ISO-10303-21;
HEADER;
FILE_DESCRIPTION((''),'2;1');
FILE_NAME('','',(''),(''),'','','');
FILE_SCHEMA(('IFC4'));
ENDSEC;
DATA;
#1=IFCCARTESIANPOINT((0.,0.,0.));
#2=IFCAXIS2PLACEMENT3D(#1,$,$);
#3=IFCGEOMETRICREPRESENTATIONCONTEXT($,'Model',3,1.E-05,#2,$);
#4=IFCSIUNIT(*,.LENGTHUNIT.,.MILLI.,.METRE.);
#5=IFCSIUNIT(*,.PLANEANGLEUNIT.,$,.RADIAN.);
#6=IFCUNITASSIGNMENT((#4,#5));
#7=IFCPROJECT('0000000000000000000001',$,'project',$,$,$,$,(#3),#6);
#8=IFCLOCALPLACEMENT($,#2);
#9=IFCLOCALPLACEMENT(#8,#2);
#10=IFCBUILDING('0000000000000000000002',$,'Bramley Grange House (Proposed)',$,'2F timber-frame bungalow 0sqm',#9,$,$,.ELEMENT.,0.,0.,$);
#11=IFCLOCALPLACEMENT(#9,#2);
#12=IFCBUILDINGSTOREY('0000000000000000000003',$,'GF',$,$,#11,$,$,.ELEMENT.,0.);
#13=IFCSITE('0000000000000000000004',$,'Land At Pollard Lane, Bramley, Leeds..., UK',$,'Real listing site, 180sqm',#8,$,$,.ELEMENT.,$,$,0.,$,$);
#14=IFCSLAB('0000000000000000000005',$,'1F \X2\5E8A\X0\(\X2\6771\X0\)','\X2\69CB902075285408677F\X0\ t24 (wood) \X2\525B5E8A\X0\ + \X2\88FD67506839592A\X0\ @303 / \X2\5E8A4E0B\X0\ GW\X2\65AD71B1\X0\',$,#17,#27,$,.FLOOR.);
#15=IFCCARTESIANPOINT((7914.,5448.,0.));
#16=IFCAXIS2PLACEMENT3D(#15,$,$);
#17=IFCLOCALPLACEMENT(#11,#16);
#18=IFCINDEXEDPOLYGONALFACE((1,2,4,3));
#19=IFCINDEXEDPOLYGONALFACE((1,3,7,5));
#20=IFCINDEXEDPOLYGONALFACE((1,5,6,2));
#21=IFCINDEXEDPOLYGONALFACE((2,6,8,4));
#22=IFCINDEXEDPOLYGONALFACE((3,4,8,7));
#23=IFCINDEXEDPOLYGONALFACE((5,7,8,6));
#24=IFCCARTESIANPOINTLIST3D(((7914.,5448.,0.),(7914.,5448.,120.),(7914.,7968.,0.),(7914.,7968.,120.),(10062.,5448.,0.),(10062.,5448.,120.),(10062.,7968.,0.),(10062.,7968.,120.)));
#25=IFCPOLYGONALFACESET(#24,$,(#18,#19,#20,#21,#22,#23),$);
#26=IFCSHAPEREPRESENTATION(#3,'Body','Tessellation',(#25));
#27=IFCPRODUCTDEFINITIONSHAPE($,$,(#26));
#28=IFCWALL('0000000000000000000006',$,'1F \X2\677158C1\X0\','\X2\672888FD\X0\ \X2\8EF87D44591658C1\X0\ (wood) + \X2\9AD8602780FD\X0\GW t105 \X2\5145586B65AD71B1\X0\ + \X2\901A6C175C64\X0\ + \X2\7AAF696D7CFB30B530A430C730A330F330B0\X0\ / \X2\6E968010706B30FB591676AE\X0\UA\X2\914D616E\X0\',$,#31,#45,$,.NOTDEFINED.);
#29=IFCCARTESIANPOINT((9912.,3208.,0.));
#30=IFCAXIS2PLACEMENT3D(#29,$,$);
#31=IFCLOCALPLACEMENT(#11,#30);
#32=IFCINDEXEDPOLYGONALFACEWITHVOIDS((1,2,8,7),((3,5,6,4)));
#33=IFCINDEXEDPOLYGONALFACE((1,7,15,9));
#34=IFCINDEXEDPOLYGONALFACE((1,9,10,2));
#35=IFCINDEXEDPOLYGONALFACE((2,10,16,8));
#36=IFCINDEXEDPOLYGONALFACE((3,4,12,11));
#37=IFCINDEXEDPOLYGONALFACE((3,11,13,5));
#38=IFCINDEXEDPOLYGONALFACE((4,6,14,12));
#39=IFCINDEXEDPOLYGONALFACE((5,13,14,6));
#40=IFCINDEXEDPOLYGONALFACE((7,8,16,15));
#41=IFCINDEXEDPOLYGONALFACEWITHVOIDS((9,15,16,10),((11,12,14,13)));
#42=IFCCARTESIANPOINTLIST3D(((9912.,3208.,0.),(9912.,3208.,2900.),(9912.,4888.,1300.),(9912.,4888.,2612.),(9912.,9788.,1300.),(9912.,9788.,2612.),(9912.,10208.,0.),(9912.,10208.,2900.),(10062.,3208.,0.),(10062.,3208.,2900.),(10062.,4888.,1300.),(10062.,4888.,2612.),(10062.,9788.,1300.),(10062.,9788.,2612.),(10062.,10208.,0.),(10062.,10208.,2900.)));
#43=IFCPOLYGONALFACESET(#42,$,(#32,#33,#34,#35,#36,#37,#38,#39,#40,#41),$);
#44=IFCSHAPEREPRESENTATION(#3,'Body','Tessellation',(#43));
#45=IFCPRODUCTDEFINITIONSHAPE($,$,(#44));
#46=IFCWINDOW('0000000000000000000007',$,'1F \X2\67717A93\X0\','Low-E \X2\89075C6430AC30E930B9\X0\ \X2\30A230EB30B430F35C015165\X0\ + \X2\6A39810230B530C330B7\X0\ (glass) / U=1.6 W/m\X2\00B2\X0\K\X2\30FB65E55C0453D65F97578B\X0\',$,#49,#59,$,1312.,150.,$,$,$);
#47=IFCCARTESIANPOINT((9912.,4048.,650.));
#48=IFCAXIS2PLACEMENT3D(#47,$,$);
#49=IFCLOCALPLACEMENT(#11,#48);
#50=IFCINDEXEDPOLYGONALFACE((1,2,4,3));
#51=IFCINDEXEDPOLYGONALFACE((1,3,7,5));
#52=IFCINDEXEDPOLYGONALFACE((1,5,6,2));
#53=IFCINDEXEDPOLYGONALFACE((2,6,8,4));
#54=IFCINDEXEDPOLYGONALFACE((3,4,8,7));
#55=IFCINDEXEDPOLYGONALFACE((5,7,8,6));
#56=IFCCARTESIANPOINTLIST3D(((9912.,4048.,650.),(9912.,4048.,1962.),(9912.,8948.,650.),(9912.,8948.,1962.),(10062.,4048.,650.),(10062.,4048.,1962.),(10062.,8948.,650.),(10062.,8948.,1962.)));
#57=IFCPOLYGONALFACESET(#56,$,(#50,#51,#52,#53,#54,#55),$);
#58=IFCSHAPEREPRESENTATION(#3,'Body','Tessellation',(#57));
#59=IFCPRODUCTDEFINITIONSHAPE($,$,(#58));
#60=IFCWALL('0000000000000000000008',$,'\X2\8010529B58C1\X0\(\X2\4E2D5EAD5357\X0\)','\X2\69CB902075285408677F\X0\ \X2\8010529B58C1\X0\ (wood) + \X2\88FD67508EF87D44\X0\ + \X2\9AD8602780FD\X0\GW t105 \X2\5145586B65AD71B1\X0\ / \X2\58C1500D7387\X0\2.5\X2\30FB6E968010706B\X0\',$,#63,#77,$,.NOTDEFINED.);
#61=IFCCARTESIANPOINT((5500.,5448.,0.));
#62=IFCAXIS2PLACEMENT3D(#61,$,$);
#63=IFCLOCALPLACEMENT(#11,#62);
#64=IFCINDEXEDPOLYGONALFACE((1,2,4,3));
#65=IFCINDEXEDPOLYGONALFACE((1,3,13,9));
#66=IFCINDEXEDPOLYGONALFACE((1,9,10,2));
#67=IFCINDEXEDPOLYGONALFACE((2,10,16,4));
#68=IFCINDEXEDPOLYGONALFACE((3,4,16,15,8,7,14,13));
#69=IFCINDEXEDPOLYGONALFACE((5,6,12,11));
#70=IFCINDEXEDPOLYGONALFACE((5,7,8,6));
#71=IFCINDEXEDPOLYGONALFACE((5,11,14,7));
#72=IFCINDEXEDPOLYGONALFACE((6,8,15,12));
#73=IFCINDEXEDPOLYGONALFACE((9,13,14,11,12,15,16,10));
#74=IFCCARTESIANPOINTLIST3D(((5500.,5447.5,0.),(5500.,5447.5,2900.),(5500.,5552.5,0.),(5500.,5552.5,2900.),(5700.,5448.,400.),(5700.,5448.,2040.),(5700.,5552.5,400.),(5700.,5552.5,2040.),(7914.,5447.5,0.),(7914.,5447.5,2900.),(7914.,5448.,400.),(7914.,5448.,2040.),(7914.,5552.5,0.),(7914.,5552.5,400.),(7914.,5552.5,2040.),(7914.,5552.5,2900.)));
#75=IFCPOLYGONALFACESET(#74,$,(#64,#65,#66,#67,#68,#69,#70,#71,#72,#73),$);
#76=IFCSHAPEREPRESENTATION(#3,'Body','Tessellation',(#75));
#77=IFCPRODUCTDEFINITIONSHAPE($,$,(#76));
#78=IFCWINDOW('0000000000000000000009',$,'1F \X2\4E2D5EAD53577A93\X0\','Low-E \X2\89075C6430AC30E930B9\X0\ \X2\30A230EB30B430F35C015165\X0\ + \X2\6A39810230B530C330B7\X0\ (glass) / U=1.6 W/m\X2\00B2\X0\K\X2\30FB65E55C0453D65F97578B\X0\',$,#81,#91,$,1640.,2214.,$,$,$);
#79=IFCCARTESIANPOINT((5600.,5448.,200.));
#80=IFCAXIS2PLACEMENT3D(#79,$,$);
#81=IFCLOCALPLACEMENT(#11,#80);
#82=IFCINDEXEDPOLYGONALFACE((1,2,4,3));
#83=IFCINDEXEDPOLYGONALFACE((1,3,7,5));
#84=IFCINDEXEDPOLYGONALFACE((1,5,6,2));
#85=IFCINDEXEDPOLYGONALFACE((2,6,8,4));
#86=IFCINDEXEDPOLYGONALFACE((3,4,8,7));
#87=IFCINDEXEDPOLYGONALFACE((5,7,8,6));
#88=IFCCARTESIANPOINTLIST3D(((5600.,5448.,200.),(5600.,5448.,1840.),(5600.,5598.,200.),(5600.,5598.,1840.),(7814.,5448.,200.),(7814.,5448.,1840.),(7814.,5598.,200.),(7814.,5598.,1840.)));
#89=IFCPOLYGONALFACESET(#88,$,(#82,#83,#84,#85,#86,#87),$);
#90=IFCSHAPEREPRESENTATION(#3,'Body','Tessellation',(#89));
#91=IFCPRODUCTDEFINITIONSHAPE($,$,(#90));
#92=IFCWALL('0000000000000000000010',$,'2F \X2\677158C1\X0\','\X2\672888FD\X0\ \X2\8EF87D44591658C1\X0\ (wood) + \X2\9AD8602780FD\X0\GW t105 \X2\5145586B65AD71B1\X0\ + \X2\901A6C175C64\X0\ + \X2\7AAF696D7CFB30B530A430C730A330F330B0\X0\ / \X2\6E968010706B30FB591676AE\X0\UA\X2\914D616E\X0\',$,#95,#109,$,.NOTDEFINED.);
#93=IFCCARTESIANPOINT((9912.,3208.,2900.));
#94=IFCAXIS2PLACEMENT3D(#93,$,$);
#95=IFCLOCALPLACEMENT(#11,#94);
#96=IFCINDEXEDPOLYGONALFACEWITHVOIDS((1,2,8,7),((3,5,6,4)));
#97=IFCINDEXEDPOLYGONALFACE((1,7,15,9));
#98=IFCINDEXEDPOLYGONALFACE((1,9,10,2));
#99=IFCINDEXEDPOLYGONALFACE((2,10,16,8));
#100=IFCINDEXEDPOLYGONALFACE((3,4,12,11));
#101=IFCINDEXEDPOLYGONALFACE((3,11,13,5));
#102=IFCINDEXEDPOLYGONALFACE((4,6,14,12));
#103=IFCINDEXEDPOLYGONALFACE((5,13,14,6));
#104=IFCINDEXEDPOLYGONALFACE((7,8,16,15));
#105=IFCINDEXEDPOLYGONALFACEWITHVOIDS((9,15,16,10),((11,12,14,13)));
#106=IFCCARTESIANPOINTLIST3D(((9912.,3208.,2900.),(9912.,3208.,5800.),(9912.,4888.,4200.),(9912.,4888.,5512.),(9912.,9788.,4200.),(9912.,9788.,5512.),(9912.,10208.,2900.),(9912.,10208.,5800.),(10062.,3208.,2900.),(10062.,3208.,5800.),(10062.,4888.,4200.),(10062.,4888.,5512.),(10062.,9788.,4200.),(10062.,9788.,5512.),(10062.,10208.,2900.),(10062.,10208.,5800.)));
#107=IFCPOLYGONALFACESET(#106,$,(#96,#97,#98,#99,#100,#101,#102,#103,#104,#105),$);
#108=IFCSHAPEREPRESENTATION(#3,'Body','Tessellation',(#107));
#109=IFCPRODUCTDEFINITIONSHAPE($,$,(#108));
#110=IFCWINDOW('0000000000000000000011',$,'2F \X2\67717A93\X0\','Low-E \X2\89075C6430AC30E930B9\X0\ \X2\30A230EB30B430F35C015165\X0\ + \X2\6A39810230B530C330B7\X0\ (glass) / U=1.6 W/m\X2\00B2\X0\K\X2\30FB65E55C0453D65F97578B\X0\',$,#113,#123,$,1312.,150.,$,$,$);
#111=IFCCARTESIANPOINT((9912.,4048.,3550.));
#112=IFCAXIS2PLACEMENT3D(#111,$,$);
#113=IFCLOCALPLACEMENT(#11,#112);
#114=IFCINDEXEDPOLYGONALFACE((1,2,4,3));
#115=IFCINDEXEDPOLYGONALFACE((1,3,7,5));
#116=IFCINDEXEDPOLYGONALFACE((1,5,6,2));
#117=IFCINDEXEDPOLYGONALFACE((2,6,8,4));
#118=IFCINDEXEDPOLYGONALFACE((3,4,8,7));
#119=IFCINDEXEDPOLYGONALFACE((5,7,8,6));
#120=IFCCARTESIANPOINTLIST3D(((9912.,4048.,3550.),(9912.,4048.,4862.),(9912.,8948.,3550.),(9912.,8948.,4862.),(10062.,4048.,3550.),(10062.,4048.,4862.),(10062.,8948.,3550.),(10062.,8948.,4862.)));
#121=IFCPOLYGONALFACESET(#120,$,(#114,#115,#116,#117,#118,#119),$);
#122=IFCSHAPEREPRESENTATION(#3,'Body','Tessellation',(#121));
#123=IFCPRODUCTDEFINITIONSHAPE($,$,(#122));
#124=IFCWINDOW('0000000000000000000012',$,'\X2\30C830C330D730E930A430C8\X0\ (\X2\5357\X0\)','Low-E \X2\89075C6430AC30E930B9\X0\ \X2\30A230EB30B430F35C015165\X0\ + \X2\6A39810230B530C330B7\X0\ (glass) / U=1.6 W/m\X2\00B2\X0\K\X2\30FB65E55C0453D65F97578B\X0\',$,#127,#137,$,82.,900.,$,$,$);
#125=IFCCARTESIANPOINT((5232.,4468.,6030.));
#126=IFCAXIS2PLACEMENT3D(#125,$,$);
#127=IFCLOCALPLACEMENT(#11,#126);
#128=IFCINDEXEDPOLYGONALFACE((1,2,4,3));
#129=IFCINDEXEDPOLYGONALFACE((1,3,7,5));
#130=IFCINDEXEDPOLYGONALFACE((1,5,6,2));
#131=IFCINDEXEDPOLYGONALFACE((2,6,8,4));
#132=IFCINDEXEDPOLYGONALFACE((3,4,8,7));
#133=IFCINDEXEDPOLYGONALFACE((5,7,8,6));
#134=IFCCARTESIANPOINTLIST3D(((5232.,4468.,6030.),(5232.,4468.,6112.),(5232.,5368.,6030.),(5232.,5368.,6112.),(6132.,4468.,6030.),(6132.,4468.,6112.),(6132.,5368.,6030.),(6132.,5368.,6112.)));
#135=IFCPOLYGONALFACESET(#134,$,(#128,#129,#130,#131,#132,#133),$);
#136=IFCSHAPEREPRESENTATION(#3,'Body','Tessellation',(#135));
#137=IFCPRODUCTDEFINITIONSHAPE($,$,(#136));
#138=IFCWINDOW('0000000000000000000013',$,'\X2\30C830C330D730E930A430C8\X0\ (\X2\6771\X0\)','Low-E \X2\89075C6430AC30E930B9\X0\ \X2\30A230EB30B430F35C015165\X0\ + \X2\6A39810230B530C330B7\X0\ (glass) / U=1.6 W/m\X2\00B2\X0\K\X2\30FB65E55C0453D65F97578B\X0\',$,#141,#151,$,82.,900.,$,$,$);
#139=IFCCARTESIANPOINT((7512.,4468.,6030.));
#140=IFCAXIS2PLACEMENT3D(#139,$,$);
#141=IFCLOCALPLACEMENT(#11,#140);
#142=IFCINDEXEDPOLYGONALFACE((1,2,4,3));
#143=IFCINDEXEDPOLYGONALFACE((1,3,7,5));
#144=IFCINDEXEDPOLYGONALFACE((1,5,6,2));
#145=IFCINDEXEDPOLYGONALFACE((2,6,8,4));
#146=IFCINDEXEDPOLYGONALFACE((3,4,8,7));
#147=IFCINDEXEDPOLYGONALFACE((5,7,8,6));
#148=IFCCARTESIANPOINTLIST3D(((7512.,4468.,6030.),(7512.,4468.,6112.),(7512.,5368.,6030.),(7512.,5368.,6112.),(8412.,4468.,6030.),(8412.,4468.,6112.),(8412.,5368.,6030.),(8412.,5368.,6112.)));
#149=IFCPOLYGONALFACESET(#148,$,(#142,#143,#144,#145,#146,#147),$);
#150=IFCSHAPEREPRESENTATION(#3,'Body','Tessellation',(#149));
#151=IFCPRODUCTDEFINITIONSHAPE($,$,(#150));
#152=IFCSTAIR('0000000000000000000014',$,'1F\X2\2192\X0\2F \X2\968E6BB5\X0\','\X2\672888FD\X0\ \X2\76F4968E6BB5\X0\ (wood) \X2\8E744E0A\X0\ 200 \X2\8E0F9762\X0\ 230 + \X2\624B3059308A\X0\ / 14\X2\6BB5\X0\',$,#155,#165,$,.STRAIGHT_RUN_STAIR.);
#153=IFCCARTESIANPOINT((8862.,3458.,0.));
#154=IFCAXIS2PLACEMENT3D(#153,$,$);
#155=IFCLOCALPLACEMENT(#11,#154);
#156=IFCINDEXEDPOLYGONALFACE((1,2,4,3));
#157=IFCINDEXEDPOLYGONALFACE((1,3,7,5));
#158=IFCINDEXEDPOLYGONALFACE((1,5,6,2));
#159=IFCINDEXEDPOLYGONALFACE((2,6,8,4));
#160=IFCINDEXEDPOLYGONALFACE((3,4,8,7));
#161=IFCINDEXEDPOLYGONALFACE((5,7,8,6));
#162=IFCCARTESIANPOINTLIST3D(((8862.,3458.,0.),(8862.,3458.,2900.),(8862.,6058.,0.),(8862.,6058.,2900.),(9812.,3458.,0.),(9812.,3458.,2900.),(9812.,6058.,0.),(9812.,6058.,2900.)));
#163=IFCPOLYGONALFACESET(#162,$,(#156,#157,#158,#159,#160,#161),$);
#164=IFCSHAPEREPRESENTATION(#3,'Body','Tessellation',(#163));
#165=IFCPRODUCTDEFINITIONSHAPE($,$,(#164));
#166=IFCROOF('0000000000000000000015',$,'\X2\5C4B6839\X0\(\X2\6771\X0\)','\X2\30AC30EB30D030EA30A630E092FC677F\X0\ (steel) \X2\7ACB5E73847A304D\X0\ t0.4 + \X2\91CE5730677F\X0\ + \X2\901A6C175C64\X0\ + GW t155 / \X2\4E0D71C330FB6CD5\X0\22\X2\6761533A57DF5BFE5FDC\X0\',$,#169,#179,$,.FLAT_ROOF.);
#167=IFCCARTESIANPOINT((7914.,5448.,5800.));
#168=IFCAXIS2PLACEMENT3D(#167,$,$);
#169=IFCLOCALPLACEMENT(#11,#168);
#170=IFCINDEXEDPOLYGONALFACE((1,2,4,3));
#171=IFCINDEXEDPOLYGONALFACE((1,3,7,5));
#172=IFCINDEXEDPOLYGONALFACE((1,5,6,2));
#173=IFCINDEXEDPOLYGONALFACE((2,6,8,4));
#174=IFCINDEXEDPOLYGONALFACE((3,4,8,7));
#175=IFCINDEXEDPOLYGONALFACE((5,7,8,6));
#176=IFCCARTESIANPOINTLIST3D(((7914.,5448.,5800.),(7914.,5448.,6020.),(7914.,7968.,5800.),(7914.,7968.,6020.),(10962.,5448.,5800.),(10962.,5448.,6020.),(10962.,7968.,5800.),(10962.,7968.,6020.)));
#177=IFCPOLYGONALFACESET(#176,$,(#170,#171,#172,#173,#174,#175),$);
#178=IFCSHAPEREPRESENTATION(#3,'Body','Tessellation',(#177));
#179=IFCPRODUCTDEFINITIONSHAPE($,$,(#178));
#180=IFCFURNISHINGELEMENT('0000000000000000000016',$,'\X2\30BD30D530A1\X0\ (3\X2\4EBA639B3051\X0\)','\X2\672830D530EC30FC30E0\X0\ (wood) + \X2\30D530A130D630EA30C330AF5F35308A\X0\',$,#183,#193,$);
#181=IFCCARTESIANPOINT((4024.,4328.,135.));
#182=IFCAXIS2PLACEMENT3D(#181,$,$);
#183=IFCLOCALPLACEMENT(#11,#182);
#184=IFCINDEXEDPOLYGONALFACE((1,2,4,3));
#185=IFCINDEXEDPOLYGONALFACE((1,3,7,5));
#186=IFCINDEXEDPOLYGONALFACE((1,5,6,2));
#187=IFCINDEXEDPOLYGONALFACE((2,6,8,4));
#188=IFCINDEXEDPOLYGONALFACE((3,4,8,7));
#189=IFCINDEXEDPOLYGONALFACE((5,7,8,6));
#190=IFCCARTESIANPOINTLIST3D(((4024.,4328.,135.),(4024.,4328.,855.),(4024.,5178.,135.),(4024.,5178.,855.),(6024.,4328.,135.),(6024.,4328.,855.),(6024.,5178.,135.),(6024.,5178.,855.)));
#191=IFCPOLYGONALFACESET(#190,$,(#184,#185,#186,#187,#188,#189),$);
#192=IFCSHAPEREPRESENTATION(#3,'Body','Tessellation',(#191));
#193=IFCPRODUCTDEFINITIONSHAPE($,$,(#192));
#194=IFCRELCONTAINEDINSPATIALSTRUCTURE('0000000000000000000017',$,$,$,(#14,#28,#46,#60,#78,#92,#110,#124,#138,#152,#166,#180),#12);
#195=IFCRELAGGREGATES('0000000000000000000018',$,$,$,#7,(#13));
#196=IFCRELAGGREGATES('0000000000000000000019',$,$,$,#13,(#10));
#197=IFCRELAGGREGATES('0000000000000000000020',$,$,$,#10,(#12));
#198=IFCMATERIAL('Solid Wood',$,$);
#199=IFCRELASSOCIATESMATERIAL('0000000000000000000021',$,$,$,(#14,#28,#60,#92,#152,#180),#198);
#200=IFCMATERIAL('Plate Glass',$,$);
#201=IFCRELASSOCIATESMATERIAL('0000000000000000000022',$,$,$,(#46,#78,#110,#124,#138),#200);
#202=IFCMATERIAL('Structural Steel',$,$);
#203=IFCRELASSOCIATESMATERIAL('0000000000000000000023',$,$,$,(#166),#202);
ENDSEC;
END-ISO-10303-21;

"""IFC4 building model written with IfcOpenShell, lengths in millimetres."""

from ifc_helpers import new_model, si_unit, frame, frame_2d, origin, place, context, project, spatial, rectangle, extrude, material, element, fill, save


model = new_model("IFC4")

# Units and contexts
model_context = context("Model", 3, precision=1e-05, world=origin())
ifc_project = project(units=[si_unit("LENGTHUNIT", "METRE", prefix="MILLI"), si_unit("PLANEANGLEUNIT", "RADIAN")], contexts=[model_context])

# Site, building, storey
site_placement = place(None, origin())
site = spatial("IfcSite", under=ifc_project, at=site_placement, Name="Land At Pollard Lane, Bramley, Leeds..., UK", ObjectType="Real listing site, 180sqm", CompositionType="ELEMENT", RefElevation=0.0)
building_placement = place(site_placement, origin())
building = spatial("IfcBuilding", under=site, at=building_placement, Name="Bramley Grange House (Proposed)", ObjectType="2F timber-frame bungalow 0sqm", CompositionType="ELEMENT", ElevationOfRefHeight=0.0, ElevationOfTerrain=0.0)
storey_placement = place(building_placement, origin())
storey = spatial("IfcBuildingStorey", under=building, at=storey_placement, Name="GF", CompositionType="ELEMENT", Elevation=0.0)

# Slab
ifc_material_1 = material(Name="Solid Wood")
slab_placement = place(storey_placement, frame((7914.0, 5448.0, 0.0)))
element("IfcSlab", 1, at=slab_placement, inside=storey, material=ifc_material_1, Name="1F 床(東)", Description="構造用合板 t24 (wood) 剛床 + 製材根太 @303 / 床下 GW断熱", PredefinedType="FLOOR", context=model_context, shape_type="SweptSolid", body=[
    extrude(rectangle(XDim=2148.0, YDim=2520.0, at=frame_2d((1074.0, 1260.0))), frame((7914.0, 5448.0, 0.0)), (0.0, 0.0, 1.0), 120.0),
])

# Walls, openings, windows
wall_1_placement = place(storey_placement, frame((9912.0, 3208.0, 0.0)))
wall_1 = element("IfcWall", 2, at=wall_1_placement, inside=storey, material=ifc_material_1, Name="1F 東壁", Description="木製 軸組外壁 (wood) + 高性能GW t105 充填断熱 + 通気層 + 窯業系サイディング / 準耐火・外皮UA配慮", PredefinedType="NOTDEFINED", context=model_context, shape_type="SweptSolid", body=[
    extrude(rectangle(XDim=150.0, YDim=7000.0, at=frame_2d((75.0, 3500.0))), frame((9912.0, 3208.0, 0.0)), (0.0, 0.0, 1.0), 2900.0),
])
opening_1_placement = place(storey_placement, frame((9912.0, 4048.0, 650.0)))
opening_1 = element("IfcOpeningElement", 3, at=opening_1_placement, cuts=wall_1, PredefinedType="NOTDEFINED", context=model_context, shape_type="SweptSolid", body=[
    extrude(rectangle(XDim=150.0, YDim=4900.0, at=frame_2d((75.0, 2450.0))), frame((9912.0, 4048.0, 650.0)), (0.0, 0.0, 1.0), 1312.0),
])
ifc_material_2 = material(Name="Plate Glass")
window_1_placement = place(storey_placement, frame((9912.0, 4048.0, 650.0)))
window_1 = element("IfcWindow", 4, at=window_1_placement, inside=storey, material=ifc_material_2, Name="1F 東窓", Description="Low-E 複層ガラス アルゴン封入 + 樹脂サッシ (glass) / U=1.6 W/m²K・日射取得型", OverallHeight=1312.0, OverallWidth=150.0, context=model_context, shape_type="SweptSolid", body=[
    extrude(rectangle(XDim=150.0, YDim=4900.0, at=frame_2d((75.0, 2450.0))), frame((9912.0, 4048.0, 650.0)), (0.0, 0.0, 1.0), 1312.0),
])
fill(opening_1, window_1)
wall_2_placement = place(storey_placement, frame((5500.0, 5448.0, 0.0)))
wall_2 = element("IfcWall", 5, at=wall_2_placement, inside=storey, material=ifc_material_1, Name="耐力壁(中庭南)", Description="構造用合板 耐力壁 (wood) + 製材軸組 + 高性能GW t105 充填断熱 / 壁倍率2.5・準耐火", PredefinedType="NOTDEFINED", context=model_context, shape_type="SweptSolid", body=[
    extrude(rectangle(XDim=2414.0, YDim=105.0, at=frame_2d((1207.0, 52.0))), frame((5500.0, 5448.0, 0.0)), (0.0, 0.0, 1.0), 2900.0),
])
opening_2_placement = place(storey_placement, frame((5600.0, 5448.0, 200.0)))
opening_2 = element("IfcOpeningElement", 6, at=opening_2_placement, cuts=wall_2, PredefinedType="NOTDEFINED", context=model_context, shape_type="SweptSolid", body=[
    extrude(rectangle(XDim=2214.0, YDim=150.0, at=frame_2d((1107.0, 75.0))), frame((5600.0, 5448.0, 200.0)), (0.0, 0.0, 1.0), 1640.0),
])
window_2_placement = place(storey_placement, frame((5600.0, 5448.0, 200.0)))
window_2 = element("IfcWindow", 7, at=window_2_placement, inside=storey, material=ifc_material_2, Name="1F 中庭南窓", Description="Low-E 複層ガラス アルゴン封入 + 樹脂サッシ (glass) / U=1.6 W/m²K・日射取得型", OverallHeight=1640.0, OverallWidth=2214.0, context=model_context, shape_type="SweptSolid", body=[
    extrude(rectangle(XDim=2214.0, YDim=150.0, at=frame_2d((1107.0, 75.0))), frame((5600.0, 5448.0, 200.0)), (0.0, 0.0, 1.0), 1640.0),
])
fill(opening_2, window_2)

# Wall, opening, window
wall_3_placement = place(storey_placement, frame((9912.0, 3208.0, 2900.0)))
wall_3 = element("IfcWall", 8, at=wall_3_placement, inside=storey, material=ifc_material_1, Name="2F 東壁", Description="木製 軸組外壁 (wood) + 高性能GW t105 充填断熱 + 通気層 + 窯業系サイディング / 準耐火・外皮UA配慮", PredefinedType="NOTDEFINED", context=model_context, shape_type="SweptSolid", body=[
    extrude(rectangle(XDim=150.0, YDim=7000.0, at=frame_2d((75.0, 3500.0))), frame((9912.0, 3208.0, 2900.0)), (0.0, 0.0, 1.0), 2900.0),
])
opening_3_placement = place(storey_placement, frame((9912.0, 4048.0, 3550.0)))
opening_3 = element("IfcOpeningElement", 9, at=opening_3_placement, cuts=wall_3, PredefinedType="NOTDEFINED", context=model_context, shape_type="SweptSolid", body=[
    extrude(rectangle(XDim=150.0, YDim=4900.0, at=frame_2d((75.0, 2450.0))), frame((9912.0, 4048.0, 3550.0)), (0.0, 0.0, 1.0), 1312.0),
])
window_3_placement = place(storey_placement, frame((9912.0, 4048.0, 3550.0)))
window_3 = element("IfcWindow", 10, at=window_3_placement, inside=storey, material=ifc_material_2, Name="2F 東窓", Description="Low-E 複層ガラス アルゴン封入 + 樹脂サッシ (glass) / U=1.6 W/m²K・日射取得型", OverallHeight=1312.0, OverallWidth=150.0, context=model_context, shape_type="SweptSolid", body=[
    extrude(rectangle(XDim=150.0, YDim=4900.0, at=frame_2d((75.0, 2450.0))), frame((9912.0, 4048.0, 3550.0)), (0.0, 0.0, 1.0), 1312.0),
])
fill(opening_3, window_3)

# Windows
window_4_placement = place(storey_placement, frame((5232.0, 4468.0, 6030.0)))
element("IfcWindow", 11, at=window_4_placement, inside=storey, material=ifc_material_2, Name="トップライト (南)", Description="Low-E 複層ガラス アルゴン封入 + 樹脂サッシ (glass) / U=1.6 W/m²K・日射取得型", OverallHeight=82.0, OverallWidth=900.0, context=model_context, shape_type="SweptSolid", body=[
    extrude(rectangle(XDim=900.0, YDim=900.0, at=frame_2d((450.0, 450.0))), frame((5232.0, 4468.0, 6030.0)), (0.0, 0.0, 1.0), 82.0),
])
window_5_placement = place(storey_placement, frame((7512.0, 4468.0, 6030.0)))
element("IfcWindow", 12, at=window_5_placement, inside=storey, material=ifc_material_2, Name="トップライト (東)", Description="Low-E 複層ガラス アルゴン封入 + 樹脂サッシ (glass) / U=1.6 W/m²K・日射取得型", OverallHeight=82.0, OverallWidth=900.0, context=model_context, shape_type="SweptSolid", body=[
    extrude(rectangle(XDim=900.0, YDim=900.0, at=frame_2d((450.0, 450.0))), frame((7512.0, 4468.0, 6030.0)), (0.0, 0.0, 1.0), 82.0),
])

# Stair
stair_placement = place(storey_placement, frame((8862.0, 3458.0, 0.0)))
element("IfcStair", 13, at=stair_placement, inside=storey, material=ifc_material_1, Name="1F→2F 階段", Description="木製 直階段 (wood) 蹴上 200 踏面 230 + 手すり / 14段", PredefinedType="STRAIGHT_RUN_STAIR", context=model_context, shape_type="SweptSolid", body=[
    extrude(rectangle(XDim=950.0, YDim=2600.0, at=frame_2d((475.0, 1300.0))), frame((8862.0, 3458.0, 0.0)), (0.0, 0.0, 1.0), 2900.0),
])

# Roof
ifc_material_3 = material(Name="Structural Steel")
roof_placement = place(storey_placement, frame((7914.0, 5448.0, 5800.0)))
element("IfcRoof", 14, at=roof_placement, inside=storey, material=ifc_material_3, Name="屋根(東)", Description="ガルバリウム鋼板 (steel) 立平葺き t0.4 + 野地板 + 通気層 + GW t155 / 不燃・法22条区域対応", PredefinedType="FLAT_ROOF", context=model_context, shape_type="SweptSolid", body=[
    extrude(rectangle(XDim=3048.0, YDim=2520.0, at=frame_2d((1524.0, 1260.0))), frame((7914.0, 5448.0, 5800.0)), (0.0, 0.0, 1.0), 220.0),
])

# Furnishing element
furnishing_1_placement = place(storey_placement, frame((4024.0, 4328.0, 135.0)))
element("IfcFurnishingElement", 15, at=furnishing_1_placement, inside=storey, material=ifc_material_1, Name="ソファ (3人掛け)", Description="木フレーム (wood) + ファブリック張り", context=model_context, shape_type="SweptSolid", body=[
    extrude(rectangle(XDim=2000.0, YDim=850.0, at=frame_2d((1000.0, 425.0))), frame((4024.0, 4328.0, 135.0)), (0.0, 0.0, 1.0), 720.0),
])

save(model, "model.ifc")
